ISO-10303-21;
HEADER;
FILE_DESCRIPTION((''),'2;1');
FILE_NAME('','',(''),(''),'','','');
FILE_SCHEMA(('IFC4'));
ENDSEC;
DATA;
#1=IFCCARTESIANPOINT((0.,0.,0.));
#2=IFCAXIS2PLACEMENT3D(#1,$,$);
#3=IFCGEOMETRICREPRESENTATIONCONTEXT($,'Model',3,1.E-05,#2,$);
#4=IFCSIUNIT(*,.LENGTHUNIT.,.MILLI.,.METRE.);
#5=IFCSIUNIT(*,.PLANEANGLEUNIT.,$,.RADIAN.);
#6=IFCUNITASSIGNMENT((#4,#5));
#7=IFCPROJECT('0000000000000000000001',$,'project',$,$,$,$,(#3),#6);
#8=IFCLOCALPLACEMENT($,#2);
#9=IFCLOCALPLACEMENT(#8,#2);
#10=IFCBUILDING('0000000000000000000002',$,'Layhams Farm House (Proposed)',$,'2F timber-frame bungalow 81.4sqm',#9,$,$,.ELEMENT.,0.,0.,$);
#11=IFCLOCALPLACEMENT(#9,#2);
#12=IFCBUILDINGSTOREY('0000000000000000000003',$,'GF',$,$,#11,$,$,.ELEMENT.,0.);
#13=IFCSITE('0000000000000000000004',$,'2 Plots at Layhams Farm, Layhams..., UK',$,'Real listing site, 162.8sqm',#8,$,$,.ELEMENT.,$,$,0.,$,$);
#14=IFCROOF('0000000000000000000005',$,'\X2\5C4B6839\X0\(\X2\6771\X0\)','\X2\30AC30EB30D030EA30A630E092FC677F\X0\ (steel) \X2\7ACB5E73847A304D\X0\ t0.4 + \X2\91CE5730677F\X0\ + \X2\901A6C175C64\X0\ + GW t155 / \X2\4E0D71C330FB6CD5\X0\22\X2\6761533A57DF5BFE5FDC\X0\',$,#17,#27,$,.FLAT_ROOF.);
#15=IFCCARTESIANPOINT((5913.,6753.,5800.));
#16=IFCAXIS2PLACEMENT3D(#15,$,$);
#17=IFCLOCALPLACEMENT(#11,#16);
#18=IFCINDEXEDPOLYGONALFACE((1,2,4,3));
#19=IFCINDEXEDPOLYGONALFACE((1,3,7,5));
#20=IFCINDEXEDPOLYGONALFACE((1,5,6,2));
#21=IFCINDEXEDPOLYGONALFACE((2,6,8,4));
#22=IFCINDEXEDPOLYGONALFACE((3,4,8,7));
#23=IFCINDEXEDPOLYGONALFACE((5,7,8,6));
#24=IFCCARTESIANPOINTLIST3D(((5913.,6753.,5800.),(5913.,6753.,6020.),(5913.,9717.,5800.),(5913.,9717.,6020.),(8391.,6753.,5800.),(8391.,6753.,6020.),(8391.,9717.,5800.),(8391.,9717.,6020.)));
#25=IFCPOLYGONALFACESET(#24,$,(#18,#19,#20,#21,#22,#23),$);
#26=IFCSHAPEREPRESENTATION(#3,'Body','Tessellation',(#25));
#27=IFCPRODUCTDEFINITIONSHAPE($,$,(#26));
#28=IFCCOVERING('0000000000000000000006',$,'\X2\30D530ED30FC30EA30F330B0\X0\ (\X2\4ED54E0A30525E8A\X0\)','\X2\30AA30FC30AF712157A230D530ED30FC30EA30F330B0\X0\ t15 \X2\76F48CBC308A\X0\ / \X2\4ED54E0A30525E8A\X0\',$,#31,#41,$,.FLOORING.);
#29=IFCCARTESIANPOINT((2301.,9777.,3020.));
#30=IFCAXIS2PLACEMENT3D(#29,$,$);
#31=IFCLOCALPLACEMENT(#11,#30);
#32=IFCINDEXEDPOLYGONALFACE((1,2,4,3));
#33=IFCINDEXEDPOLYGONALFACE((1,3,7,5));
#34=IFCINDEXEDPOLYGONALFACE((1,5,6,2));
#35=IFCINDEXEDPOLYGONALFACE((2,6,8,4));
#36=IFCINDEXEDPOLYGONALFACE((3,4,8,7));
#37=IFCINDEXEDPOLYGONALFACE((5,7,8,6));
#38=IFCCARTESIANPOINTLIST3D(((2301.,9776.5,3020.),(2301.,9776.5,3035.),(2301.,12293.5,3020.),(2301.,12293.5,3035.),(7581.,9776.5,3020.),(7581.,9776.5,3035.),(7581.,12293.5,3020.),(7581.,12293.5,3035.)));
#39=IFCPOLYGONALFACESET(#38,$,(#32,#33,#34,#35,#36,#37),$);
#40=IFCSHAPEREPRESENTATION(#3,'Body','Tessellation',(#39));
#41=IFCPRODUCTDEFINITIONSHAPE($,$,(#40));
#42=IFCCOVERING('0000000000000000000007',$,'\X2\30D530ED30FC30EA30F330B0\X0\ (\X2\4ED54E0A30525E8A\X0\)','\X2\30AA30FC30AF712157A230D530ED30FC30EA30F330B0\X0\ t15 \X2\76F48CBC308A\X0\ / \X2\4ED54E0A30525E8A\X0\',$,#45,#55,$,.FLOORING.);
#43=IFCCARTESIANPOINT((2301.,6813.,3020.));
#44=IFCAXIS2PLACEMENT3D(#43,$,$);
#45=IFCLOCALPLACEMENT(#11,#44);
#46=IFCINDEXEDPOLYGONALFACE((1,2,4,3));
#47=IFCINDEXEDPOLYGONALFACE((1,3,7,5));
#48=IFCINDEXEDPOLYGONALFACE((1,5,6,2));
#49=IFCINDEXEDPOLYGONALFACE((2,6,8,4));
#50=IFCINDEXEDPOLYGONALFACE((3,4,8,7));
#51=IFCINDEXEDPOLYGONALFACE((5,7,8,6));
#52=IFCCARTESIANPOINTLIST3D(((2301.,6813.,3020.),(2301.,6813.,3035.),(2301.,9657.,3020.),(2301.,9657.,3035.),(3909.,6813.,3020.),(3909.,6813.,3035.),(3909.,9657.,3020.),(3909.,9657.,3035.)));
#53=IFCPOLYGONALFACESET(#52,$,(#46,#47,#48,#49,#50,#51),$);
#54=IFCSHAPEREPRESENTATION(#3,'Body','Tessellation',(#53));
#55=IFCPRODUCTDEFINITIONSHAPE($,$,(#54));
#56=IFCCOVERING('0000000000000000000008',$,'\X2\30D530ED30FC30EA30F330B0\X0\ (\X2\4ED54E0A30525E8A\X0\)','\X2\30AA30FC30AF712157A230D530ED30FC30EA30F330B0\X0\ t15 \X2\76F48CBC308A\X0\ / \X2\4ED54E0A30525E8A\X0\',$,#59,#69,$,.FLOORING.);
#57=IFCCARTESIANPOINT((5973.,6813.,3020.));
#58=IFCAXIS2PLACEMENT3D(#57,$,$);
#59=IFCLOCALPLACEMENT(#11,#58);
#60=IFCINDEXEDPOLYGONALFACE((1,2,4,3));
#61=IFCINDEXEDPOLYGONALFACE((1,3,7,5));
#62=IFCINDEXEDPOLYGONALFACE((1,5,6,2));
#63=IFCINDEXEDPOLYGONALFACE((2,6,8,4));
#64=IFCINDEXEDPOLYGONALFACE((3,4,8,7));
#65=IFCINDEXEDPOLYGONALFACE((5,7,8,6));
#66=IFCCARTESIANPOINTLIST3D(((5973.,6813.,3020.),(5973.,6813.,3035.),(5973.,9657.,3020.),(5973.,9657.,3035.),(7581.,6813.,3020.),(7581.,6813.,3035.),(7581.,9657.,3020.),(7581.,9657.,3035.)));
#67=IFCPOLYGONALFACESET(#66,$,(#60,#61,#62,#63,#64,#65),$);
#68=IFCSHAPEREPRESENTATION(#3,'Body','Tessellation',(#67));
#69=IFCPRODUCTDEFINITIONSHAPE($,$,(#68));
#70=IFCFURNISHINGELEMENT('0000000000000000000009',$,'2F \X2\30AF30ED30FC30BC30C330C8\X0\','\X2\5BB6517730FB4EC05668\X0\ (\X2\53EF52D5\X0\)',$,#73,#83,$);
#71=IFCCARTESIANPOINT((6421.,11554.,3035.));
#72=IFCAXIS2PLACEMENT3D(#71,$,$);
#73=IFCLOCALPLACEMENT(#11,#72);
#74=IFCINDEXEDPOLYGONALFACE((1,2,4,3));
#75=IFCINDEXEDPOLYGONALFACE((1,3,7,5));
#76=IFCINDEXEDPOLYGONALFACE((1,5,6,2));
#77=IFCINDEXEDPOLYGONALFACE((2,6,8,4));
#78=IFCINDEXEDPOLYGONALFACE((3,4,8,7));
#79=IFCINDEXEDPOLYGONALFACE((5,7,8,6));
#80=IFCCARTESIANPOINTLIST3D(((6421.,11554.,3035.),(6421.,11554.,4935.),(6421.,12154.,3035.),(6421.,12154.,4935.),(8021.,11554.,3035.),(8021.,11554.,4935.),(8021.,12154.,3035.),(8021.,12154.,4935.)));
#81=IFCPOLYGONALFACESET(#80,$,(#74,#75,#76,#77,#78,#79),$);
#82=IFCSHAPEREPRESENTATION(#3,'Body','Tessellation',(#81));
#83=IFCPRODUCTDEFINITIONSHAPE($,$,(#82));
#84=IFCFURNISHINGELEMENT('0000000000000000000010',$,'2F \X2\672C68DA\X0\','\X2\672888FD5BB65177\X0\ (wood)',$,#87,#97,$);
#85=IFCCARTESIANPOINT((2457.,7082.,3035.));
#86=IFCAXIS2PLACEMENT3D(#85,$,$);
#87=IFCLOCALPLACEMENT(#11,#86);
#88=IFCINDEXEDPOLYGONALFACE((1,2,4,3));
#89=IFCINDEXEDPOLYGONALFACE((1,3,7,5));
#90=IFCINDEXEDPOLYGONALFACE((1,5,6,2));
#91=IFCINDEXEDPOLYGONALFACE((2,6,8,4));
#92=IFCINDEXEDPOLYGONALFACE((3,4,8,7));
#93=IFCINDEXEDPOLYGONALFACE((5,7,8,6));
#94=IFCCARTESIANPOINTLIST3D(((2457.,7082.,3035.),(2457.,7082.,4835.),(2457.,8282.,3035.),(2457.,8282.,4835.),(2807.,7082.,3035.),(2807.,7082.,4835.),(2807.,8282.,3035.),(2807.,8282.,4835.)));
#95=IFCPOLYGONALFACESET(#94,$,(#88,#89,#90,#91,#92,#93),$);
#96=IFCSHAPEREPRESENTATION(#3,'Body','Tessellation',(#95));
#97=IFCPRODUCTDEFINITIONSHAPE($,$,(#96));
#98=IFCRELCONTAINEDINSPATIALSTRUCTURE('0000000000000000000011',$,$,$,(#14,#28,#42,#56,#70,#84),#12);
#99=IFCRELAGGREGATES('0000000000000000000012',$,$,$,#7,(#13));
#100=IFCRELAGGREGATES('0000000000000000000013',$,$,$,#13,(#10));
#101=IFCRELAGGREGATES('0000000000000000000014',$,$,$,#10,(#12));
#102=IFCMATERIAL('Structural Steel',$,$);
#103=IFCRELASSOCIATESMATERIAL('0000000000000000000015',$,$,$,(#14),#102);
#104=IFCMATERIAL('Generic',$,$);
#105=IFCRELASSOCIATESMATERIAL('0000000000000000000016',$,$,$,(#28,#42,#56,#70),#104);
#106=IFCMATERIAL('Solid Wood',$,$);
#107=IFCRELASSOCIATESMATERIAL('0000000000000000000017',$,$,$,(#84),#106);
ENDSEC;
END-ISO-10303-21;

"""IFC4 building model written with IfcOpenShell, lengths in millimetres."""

from ifc_helpers import new_model, si_unit, frame, frame_2d, origin, place, context, project, spatial, rectangle, extrude, material, element, save


model = new_model("IFC4")

# Units and contexts
model_context = context("Model", 3, precision=1e-05, world=origin())
ifc_project = project(units=[si_unit("LENGTHUNIT", "METRE", prefix="MILLI"), si_unit("PLANEANGLEUNIT", "RADIAN")], contexts=[model_context])

# Site, building, storey
site_placement = place(None, origin())
site = spatial("IfcSite", under=ifc_project, at=site_placement, Name="2 Plots at Layhams Farm, Layhams..., UK", ObjectType="Real listing site, 162.8sqm", CompositionType="ELEMENT", RefElevation=0.0)
building_placement = place(site_placement, origin())
building = spatial("IfcBuilding", under=site, at=building_placement, Name="Layhams Farm House (Proposed)", ObjectType="2F timber-frame bungalow 81.4sqm", CompositionType="ELEMENT", ElevationOfRefHeight=0.0, ElevationOfTerrain=0.0)
storey_placement = place(building_placement, origin())
storey = spatial("IfcBuildingStorey", under=building, at=storey_placement, Name="GF", CompositionType="ELEMENT", Elevation=0.0)

# Shared definitions
ifc_material_1 = material(Name="Solid Wood")

# Roof
ifc_material_2 = material(Name="Structural Steel")
roof_1_placement = place(storey_placement, frame((5913.0, 6753.0, 5800.0)))
element("IfcRoof", 1, at=roof_1_placement, inside=storey, material=ifc_material_2, Name="屋根(東)", Description="ガルバリウム鋼板 (steel) 立平葺き t0.4 + 野地板 + 通気層 + GW t155 / 不燃・法22条区域対応", PredefinedType="FLAT_ROOF", context=model_context, shape_type="SweptSolid", body=[
    extrude(rectangle(XDim=2478.0, YDim=2964.0, at=frame_2d((1239.0, 1482.0))), frame((5913.0, 6753.0, 5800.0)), (0.0, 0.0, 1.0), 220.0),
])

# Coverings
ifc_material_3 = material(Name="Generic")
covering_1_placement = place(storey_placement, frame((2301.0, 9777.0, 3020.0)))
element("IfcCovering", 2, at=covering_1_placement, inside=storey, material=ifc_material_3, Name="フローリング (仕上げ床)", Description="オーク無垢フローリング t15 直貼り / 仕上げ床", PredefinedType="FLOORING", context=model_context, shape_type="SweptSolid", body=[
    extrude(rectangle(XDim=5280.0, YDim=2517.0, at=frame_2d((2640.0, 1258.0))), frame((2301.0, 9777.0, 3020.0)), (0.0, 0.0, 1.0), 15.0),
])
covering_2_placement = place(storey_placement, frame((2301.0, 6813.0, 3020.0)))
element("IfcCovering", 3, at=covering_2_placement, inside=storey, material=ifc_material_3, Name="フローリング (仕上げ床)", Description="オーク無垢フローリング t15 直貼り / 仕上げ床", PredefinedType="FLOORING", context=model_context, shape_type="SweptSolid", body=[
    extrude(rectangle(XDim=1608.0, YDim=2844.0, at=frame_2d((804.0, 1422.0))), frame((2301.0, 6813.0, 3020.0)), (0.0, 0.0, 1.0), 15.0),
])
covering_3_placement = place(storey_placement, frame((5973.0, 6813.0, 3020.0)))
element("IfcCovering", 4, at=covering_3_placement, inside=storey, material=ifc_material_3, Name="フローリング (仕上げ床)", Description="オーク無垢フローリング t15 直貼り / 仕上げ床", PredefinedType="FLOORING", context=model_context, shape_type="SweptSolid", body=[
    extrude(rectangle(XDim=1608.0, YDim=2844.0, at=frame_2d((804.0, 1422.0))), frame((5973.0, 6813.0, 3020.0)), (0.0, 0.0, 1.0), 15.0),
])

# Furnishing elements
furnishing_1_placement = place(storey_placement, frame((6421.0, 11554.0, 3035.0)))
element("IfcFurnishingElement", 5, at=furnishing_1_placement, inside=storey, material=ifc_material_3, Name="2F クローゼット", Description="家具・什器 (可動)", context=model_context, shape_type="SweptSolid", body=[
    extrude(rectangle(XDim=1600.0, YDim=600.0, at=frame_2d((800.0, 300.0))), frame((6421.0, 11554.0, 3035.0)), (0.0, 0.0, 1.0), 1900.0),
])
furnishing_2_placement = place(storey_placement, frame((2457.0, 7082.0, 3035.0)))
element("IfcFurnishingElement", 6, at=furnishing_2_placement, inside=storey, material=ifc_material_1, Name="2F 本棚", Description="木製家具 (wood)", context=model_context, shape_type="SweptSolid", body=[
    extrude(rectangle(XDim=350.0, YDim=1200.0, at=frame_2d((175.0, 600.0))), frame((2457.0, 7082.0, 3035.0)), (0.0, 0.0, 1.0), 1800.0),
])

save(model, "model.ifc")
